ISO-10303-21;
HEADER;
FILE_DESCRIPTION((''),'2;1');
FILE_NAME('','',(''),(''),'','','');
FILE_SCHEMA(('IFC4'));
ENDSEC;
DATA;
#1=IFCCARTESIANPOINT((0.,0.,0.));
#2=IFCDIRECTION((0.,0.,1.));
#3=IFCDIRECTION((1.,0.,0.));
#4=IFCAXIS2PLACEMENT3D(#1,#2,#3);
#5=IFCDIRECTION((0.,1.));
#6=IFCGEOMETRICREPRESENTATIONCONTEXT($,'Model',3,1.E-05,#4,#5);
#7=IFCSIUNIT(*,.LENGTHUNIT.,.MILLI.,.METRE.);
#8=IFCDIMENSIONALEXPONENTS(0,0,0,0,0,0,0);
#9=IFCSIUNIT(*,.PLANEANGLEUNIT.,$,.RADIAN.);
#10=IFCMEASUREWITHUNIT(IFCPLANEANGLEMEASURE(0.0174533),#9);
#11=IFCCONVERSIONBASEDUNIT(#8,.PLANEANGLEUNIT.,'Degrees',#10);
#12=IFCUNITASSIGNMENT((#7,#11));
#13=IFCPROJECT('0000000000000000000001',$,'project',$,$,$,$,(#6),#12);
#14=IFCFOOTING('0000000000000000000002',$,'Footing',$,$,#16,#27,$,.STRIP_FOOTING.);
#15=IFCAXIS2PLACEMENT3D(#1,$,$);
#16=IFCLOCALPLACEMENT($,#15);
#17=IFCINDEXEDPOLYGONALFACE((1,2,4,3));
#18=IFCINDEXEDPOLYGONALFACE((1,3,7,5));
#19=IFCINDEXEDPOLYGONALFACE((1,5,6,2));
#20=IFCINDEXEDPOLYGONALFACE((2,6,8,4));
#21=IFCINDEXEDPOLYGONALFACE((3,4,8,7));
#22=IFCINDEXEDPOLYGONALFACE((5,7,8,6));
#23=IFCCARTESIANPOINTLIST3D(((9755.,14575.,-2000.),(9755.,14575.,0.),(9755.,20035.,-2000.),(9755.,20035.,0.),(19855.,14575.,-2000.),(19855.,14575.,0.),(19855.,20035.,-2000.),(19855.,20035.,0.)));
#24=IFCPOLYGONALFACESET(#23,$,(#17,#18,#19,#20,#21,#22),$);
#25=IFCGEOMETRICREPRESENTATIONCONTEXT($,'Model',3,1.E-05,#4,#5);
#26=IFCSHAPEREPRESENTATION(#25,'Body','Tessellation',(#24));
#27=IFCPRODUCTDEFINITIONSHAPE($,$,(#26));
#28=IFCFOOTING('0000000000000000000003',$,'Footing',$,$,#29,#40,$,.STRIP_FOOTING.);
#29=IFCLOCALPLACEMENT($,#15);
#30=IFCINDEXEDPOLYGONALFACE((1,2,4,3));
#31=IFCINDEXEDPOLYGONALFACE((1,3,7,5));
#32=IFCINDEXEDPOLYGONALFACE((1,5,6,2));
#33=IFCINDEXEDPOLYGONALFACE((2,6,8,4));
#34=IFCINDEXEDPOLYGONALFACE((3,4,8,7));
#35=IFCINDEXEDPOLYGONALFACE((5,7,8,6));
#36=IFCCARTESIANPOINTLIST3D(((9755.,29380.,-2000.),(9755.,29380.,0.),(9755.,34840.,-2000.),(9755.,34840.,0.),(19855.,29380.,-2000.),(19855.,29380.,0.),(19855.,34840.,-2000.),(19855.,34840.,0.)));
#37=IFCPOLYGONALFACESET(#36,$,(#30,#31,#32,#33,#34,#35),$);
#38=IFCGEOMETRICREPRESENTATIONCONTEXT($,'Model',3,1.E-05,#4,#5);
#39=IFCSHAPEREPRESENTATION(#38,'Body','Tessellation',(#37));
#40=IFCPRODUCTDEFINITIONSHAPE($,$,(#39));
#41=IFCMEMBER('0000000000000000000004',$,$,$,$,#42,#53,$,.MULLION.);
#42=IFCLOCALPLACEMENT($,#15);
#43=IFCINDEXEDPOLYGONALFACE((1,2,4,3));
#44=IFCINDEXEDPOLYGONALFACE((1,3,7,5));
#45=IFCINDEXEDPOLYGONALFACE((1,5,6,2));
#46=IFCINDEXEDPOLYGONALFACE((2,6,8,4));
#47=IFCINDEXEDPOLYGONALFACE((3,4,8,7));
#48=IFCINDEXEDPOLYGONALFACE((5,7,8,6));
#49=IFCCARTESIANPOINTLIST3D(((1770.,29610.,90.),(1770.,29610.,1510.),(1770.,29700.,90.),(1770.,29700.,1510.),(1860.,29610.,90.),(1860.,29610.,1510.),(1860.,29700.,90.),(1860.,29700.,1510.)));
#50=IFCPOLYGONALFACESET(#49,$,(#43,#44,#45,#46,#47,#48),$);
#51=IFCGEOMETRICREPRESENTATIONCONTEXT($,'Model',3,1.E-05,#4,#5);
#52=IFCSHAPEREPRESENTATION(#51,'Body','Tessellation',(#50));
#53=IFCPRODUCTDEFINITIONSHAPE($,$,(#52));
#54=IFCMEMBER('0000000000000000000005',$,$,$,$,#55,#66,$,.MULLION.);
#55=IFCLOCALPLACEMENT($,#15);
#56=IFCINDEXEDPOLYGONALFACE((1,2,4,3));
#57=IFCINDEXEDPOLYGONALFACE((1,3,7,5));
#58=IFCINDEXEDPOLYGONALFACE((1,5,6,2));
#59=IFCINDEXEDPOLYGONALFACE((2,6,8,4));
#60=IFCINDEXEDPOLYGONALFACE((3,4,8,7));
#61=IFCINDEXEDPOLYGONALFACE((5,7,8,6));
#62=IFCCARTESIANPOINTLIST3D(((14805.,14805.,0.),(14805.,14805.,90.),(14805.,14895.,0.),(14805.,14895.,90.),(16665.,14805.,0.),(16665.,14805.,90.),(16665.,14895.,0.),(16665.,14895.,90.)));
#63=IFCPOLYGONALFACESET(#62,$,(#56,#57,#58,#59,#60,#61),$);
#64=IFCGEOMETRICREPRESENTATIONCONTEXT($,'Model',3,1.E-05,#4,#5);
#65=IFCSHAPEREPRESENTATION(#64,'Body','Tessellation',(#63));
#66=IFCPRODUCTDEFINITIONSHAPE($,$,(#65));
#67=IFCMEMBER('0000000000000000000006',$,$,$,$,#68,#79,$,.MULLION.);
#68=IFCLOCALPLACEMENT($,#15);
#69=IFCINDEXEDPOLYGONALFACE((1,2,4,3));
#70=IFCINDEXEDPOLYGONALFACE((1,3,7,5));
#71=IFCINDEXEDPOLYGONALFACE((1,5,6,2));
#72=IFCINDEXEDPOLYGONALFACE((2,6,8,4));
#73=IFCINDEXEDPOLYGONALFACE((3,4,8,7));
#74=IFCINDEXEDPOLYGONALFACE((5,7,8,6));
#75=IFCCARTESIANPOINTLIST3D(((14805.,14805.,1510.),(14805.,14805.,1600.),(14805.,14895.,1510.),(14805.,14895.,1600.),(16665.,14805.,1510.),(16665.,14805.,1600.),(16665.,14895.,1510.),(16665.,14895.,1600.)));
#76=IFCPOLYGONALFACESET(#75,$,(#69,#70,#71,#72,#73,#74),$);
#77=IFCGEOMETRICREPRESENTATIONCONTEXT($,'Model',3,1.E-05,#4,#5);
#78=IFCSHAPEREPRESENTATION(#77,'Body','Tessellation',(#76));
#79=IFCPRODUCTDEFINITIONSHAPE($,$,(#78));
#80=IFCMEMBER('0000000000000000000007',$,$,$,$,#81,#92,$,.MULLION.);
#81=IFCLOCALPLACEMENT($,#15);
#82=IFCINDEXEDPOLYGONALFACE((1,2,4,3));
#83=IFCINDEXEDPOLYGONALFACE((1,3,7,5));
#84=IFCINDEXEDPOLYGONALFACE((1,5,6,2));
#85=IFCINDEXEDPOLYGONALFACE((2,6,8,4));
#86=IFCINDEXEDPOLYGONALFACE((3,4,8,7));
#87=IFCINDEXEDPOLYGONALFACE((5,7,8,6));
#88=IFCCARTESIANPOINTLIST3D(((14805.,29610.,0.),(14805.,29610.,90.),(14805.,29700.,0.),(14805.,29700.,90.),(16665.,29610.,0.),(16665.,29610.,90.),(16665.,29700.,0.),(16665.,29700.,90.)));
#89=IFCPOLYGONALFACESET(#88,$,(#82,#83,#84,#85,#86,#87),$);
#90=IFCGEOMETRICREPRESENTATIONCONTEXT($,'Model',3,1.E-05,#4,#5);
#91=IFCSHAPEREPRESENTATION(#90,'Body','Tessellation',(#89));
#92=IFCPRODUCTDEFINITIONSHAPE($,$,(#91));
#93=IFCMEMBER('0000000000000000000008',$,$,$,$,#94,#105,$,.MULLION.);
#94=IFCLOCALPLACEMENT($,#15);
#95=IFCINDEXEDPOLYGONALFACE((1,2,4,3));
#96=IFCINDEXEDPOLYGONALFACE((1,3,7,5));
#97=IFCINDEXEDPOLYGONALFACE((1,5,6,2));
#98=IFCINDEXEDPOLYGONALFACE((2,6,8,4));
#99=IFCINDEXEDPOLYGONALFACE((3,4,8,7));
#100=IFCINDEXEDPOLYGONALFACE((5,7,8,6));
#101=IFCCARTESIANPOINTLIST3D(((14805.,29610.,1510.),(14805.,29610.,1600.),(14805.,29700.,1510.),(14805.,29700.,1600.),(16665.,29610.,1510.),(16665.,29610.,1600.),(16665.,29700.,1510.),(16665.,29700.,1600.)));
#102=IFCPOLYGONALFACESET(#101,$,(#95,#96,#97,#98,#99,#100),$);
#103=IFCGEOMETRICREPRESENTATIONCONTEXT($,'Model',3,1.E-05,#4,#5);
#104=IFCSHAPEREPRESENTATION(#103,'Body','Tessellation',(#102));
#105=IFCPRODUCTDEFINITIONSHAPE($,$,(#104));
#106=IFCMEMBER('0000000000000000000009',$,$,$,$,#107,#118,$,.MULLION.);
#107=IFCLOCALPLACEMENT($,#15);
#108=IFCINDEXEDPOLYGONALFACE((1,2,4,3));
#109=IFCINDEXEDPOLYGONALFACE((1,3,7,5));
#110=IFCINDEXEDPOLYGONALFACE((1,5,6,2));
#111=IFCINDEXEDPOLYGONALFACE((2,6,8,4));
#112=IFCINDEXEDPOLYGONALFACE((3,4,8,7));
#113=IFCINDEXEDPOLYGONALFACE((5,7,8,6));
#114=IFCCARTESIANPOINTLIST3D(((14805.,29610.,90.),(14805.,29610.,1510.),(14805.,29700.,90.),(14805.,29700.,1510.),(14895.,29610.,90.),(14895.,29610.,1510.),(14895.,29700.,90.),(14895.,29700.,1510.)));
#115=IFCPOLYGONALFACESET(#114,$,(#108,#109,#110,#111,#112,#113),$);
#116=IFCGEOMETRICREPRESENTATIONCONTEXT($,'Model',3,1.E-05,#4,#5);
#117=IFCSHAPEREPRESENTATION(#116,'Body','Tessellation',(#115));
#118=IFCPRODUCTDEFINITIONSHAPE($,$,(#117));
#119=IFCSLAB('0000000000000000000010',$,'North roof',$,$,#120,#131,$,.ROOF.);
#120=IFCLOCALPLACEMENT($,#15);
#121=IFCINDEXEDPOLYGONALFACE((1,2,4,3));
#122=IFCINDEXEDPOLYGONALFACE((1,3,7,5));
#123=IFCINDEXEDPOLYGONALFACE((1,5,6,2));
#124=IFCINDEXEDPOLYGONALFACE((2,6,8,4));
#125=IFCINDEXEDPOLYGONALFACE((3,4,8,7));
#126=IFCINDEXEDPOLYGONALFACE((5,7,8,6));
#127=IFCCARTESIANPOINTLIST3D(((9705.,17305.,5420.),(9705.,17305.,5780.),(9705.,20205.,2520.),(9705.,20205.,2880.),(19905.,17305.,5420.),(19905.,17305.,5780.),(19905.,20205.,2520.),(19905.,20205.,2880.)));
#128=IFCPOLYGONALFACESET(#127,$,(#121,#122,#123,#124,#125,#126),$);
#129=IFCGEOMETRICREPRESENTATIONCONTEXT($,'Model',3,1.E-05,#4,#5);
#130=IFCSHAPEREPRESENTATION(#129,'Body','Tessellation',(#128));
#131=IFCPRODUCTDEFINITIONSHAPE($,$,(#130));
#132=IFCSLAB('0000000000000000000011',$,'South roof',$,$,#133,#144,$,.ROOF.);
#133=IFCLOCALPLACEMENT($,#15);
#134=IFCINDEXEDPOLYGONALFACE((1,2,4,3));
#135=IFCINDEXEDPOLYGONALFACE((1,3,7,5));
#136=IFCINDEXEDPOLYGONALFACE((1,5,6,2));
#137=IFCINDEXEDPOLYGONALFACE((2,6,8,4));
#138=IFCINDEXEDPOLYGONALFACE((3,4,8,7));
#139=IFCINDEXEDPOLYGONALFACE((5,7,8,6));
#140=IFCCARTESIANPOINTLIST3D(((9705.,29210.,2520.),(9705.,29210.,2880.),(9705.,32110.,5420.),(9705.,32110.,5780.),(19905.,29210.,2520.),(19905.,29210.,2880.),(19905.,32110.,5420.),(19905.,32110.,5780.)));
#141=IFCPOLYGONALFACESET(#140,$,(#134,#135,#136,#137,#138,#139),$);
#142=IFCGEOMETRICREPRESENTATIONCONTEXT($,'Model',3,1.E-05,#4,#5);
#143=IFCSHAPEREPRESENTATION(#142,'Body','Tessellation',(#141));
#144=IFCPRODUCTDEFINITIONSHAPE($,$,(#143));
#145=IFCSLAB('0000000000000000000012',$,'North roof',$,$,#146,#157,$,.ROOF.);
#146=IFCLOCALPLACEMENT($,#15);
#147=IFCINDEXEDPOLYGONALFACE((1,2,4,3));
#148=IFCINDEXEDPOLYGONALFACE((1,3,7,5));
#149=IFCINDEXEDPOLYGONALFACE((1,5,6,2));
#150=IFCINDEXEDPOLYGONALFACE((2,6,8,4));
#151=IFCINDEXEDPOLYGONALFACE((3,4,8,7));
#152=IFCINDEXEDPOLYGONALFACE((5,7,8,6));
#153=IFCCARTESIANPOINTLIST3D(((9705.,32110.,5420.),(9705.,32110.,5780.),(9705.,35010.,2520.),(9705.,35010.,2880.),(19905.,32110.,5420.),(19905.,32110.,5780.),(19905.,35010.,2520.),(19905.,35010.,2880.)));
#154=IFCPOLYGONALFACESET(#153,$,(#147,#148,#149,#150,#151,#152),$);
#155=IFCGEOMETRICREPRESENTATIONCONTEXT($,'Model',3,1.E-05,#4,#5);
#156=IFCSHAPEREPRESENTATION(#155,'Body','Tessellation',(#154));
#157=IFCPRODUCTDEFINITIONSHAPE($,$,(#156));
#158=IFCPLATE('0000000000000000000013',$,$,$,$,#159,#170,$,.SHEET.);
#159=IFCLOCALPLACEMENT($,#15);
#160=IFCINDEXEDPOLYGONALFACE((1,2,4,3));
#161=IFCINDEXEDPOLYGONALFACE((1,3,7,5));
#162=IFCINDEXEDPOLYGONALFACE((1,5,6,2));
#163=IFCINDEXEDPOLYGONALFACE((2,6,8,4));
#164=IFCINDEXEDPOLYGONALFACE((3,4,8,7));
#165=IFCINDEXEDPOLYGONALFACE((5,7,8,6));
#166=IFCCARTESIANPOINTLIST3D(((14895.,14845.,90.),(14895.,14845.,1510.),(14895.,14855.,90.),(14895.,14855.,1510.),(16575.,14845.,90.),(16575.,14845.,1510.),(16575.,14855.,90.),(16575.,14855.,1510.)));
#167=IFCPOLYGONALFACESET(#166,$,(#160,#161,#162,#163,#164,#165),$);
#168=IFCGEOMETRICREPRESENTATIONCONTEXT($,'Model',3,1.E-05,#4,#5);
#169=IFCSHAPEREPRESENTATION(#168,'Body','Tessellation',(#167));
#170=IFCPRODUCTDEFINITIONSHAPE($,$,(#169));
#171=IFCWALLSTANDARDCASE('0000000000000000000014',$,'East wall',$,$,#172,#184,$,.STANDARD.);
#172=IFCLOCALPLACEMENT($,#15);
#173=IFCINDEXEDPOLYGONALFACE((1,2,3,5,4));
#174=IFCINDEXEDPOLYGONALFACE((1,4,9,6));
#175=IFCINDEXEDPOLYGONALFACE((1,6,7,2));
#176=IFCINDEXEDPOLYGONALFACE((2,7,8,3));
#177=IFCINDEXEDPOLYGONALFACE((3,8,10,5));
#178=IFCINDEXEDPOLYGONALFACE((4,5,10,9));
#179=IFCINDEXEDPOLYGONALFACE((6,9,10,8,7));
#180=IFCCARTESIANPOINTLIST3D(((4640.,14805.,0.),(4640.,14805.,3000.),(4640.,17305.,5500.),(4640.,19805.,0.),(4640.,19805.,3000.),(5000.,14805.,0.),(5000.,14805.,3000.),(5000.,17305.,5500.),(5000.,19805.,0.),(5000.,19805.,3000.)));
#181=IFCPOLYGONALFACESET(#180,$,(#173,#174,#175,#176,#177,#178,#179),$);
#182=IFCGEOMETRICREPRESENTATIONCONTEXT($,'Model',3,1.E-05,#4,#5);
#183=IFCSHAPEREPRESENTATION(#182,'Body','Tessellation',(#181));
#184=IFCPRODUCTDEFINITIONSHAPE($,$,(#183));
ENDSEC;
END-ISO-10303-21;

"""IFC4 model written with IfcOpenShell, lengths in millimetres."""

from ifc_helpers import new_model, entity, si_unit, converted_unit, direction, frame, origin_with_axes, place, context, project, polyline, outline, extrude, clip, halfspace, source, transform, mapped, element, save


model = new_model("IFC4")

# Units and contexts
model_context_1 = context("Model", 3, precision=1e-05, world=origin_with_axes(), true_north=direction((0.0, 1.0)))
model_context_2 = context("Model", 3, precision=1e-05, world=origin_with_axes(), true_north=direction((0.0, 1.0)))
model_context_3 = context("Model", 3, precision=1e-05, world=origin_with_axes(), true_north=direction((0.0, 1.0)))
model_context_4 = context("Model", 3, precision=1e-05, world=origin_with_axes(), true_north=direction((0.0, 1.0)))
model_context_5 = context("Model", 3, precision=1e-05, world=origin_with_axes(), true_north=direction((0.0, 1.0)))
model_context_6 = context("Model", 3, precision=1e-05, world=origin_with_axes(), true_north=direction((0.0, 1.0)))
model_context_7 = context("Model", 3, precision=1e-05, world=origin_with_axes(), true_north=direction((0.0, 1.0)))
model_context_8 = context("Model", 3, precision=1e-05, world=origin_with_axes(), true_north=direction((0.0, 1.0)))
model_context_9 = context("Model", 3, precision=1e-05, world=origin_with_axes(), true_north=direction((0.0, 1.0)))
model_context_10 = context("Model", 3, precision=1e-05, world=origin_with_axes(), true_north=direction((0.0, 1.0)))
model_context_11 = context("Model", 3, precision=1e-05, world=origin_with_axes(), true_north=direction((0.0, 1.0)))
model_context_12 = context("Model", 3, precision=1e-05, world=origin_with_axes(), true_north=direction((0.0, 1.0)))
model_context_13 = context("Model", 3, precision=1e-05, world=origin_with_axes(), true_north=direction((0.0, 1.0)))
model_context_14 = context("Model", 3, precision=1e-05, world=origin_with_axes(), true_north=direction((0.0, 1.0)))
ifc_project = project(units=[si_unit("LENGTHUNIT", "METRE", prefix="MILLI"), converted_unit("PLANEANGLEUNIT", "Degrees", entity("IfcPlaneAngleMeasure", 0.0174533), si_unit("PLANEANGLEUNIT", "RADIAN"), dimensions=[0, 0, 0, 0, 0, 0, 0])], contexts=[model_context_1])

# Footings
placement_1 = place(None, frame((14805.0, 14805.0, 0.0)))
footing_1_placement = place(placement_1, frame((0.0, 2500.0, -2000.0), z_axis=(0.0, 0.0, 1.0), x_axis=(1.0, 0.0, 0.0)))
element("IfcFooting", 1, at=footing_1_placement, Name="Footing", PredefinedType="STRIP_FOOTING", context=model_context_4, shape_type="SweptSolid", body=[
    extrude(outline(polyline([(-5050.0, -2730.0), (5050.0, -2730.0), (5050.0, 2730.0), (-5050.0, 2730.0), (-5050.0, -2730.0), (-5050.0, -2730.0)])), origin_with_axes(), (0.0, 0.0, 1.0), 2000.0),
])
placement_2 = place(None, frame((14805.0, 29610.0, 0.0)))
footing_2_placement = place(placement_2, frame((0.0, 2500.0, -2000.0), z_axis=(0.0, 0.0, 1.0), x_axis=(1.0, 0.0, 0.0)))
element("IfcFooting", 2, at=footing_2_placement, Name="Footing", PredefinedType="STRIP_FOOTING", context=model_context_9, shape_type="SweptSolid", body=[
    extrude(outline(polyline([(-5050.0, -2730.0), (5050.0, -2730.0), (5050.0, 2730.0), (-5050.0, 2730.0), (-5050.0, -2730.0), (-5050.0, -2730.0)])), origin_with_axes(), (0.0, 0.0, 1.0), 2000.0),
])

# Members
shared_shape_1 = source(origin_with_axes(), model_context_3, "Body", "SweptSolid", [
    extrude(outline(polyline([(-45.0, -45.0), (45.0, -45.0), (45.0, 45.0), (-45.0, 45.0), (-45.0, -45.0), (-45.0, -45.0)])), origin_with_axes(), (0.0, 0.0, 1.0), 1420.0),
])
placement_3 = place(None, frame((0.0, 29610.0, 0.0)))
member_1_placement = place(placement_3, frame((1815.0, 45.0, 90.0), z_axis=(0.0, 0.0, 1.0), x_axis=(1.0, 0.0, 0.0)))
element("IfcMember", 3, at=member_1_placement, PredefinedType="MULLION", context=model_context_3, shape_type="MappedRepresentation", body=[
    mapped(shared_shape_1, transform((0.0, 0.0, 0.0))),
])
shared_shape_2 = source(origin_with_axes(), model_context_5, "Body", "SweptSolid", [
    extrude(outline(polyline([(-930.0, -45.0), (930.0, -45.0), (930.0, 45.0), (-930.0, 45.0), (-930.0, -45.0), (-930.0, -45.0)])), origin_with_axes(), (0.0, 0.0, 1.0), 90.0),
])
member_2_placement = place(placement_1, frame((930.0, 45.0, 0.0), z_axis=(0.0, 0.0, 1.0), x_axis=(1.0, 0.0, 0.0)))
element("IfcMember", 4, at=member_2_placement, PredefinedType="MULLION", context=model_context_5, shape_type="MappedRepresentation", body=[
    mapped(shared_shape_2, transform((0.0, 0.0, 0.0))),
])
shared_shape_3 = source(origin_with_axes(), model_context_6, "Body", "SweptSolid", [
    extrude(outline(polyline([(-930.0, -45.0), (930.0, -45.0), (930.0, 45.0), (-930.0, 45.0), (-930.0, -45.0), (-930.0, -45.0)])), origin_with_axes(), (0.0, 0.0, 1.0), 90.0),
])
member_3_placement = place(placement_1, frame((930.0, 45.0, 1510.0), z_axis=(0.0, 0.0, 1.0), x_axis=(1.0, 0.0, 0.0)))
element("IfcMember", 5, at=member_3_placement, PredefinedType="MULLION", context=model_context_6, shape_type="MappedRepresentation", body=[
    mapped(shared_shape_3, transform((0.0, 0.0, 0.0))),
])
shared_shape_4 = source(origin_with_axes(), model_context_10, "Body", "SweptSolid", [
    extrude(outline(polyline([(-930.0, -45.0), (930.0, -45.0), (930.0, 45.0), (-930.0, 45.0), (-930.0, -45.0), (-930.0, -45.0)])), origin_with_axes(), (0.0, 0.0, 1.0), 90.0),
])
member_4_placement = place(placement_2, frame((930.0, 45.0, 0.0), z_axis=(0.0, 0.0, 1.0), x_axis=(1.0, 0.0, 0.0)))
element("IfcMember", 6, at=member_4_placement, PredefinedType="MULLION", context=model_context_10, shape_type="MappedRepresentation", body=[
    mapped(shared_shape_4, transform((0.0, 0.0, 0.0))),
])
shared_shape_5 = source(origin_with_axes(), model_context_11, "Body", "SweptSolid", [
    extrude(outline(polyline([(-930.0, -45.0), (930.0, -45.0), (930.0, 45.0), (-930.0, 45.0), (-930.0, -45.0), (-930.0, -45.0)])), origin_with_axes(), (0.0, 0.0, 1.0), 90.0),
])
member_5_placement = place(placement_2, frame((930.0, 45.0, 1510.0), z_axis=(0.0, 0.0, 1.0), x_axis=(1.0, 0.0, 0.0)))
element("IfcMember", 7, at=member_5_placement, PredefinedType="MULLION", context=model_context_11, shape_type="MappedRepresentation", body=[
    mapped(shared_shape_5, transform((0.0, 0.0, 0.0))),
])
shared_shape_6 = source(origin_with_axes(), model_context_12, "Body", "SweptSolid", [
    extrude(outline(polyline([(-45.0, -45.0), (45.0, -45.0), (45.0, 45.0), (-45.0, 45.0), (-45.0, -45.0), (-45.0, -45.0)])), origin_with_axes(), (0.0, 0.0, 1.0), 1420.0),
])
member_6_placement = place(placement_2, frame((45.0, 45.0, 90.0), z_axis=(0.0, 0.0, 1.0), x_axis=(1.0, 0.0, 0.0)))
element("IfcMember", 8, at=member_6_placement, PredefinedType="MULLION", context=model_context_12, shape_type="MappedRepresentation", body=[
    mapped(shared_shape_6, transform((0.0, 0.0, 0.0))),
])

# Slabs
shared_shape_7 = source(origin_with_axes(), model_context_8, "Body", "SweptSolid", [
    extrude(outline(polyline([(-5100.0, -180.0), (5100.0, -180.0), (5100.0, 180.0), (-5100.0, 180.0), (-5100.0, -180.0), (-5100.0, -180.0)])), frame((0.0, 0.0, 0.0), z_axis=(0.0, 1.0, 0.0), x_axis=(1.0, 0.0, 0.0)), (0.0, -0.707107, 0.707107), 4101.2),
])
slab_1_placement = place(placement_1, frame((0.0, 5400.0, 2700.0), z_axis=(0.0, 0.0, 1.0), x_axis=(-1.0, 0.0, 0.0)))
element("IfcSlab", 9, at=slab_1_placement, Name="North roof", PredefinedType="ROOF", context=model_context_8, shape_type="MappedRepresentation", body=[
    mapped(shared_shape_7, transform((0.0, 0.0, 0.0))),
])
shared_shape_8 = source(origin_with_axes(), model_context_13, "Body", "SweptSolid", [
    extrude(outline(polyline([(-5100.0, -180.0), (5100.0, -180.0), (5100.0, 180.0), (-5100.0, 180.0), (-5100.0, -180.0), (-5100.0, -180.0)])), frame((0.0, 0.0, 0.0), z_axis=(0.0, 1.0, 0.0), x_axis=(1.0, 0.0, 0.0)), (0.0, -0.707107, 0.707107), 4101.2),
])
slab_2_placement = place(placement_2, frame((0.0, -400.0, 2700.0), z_axis=(0.0, 0.0, 1.0), x_axis=(1.0, 0.0, 0.0)))
element("IfcSlab", 10, at=slab_2_placement, Name="South roof", PredefinedType="ROOF", context=model_context_13, shape_type="MappedRepresentation", body=[
    mapped(shared_shape_8, transform((0.0, 0.0, 0.0))),
])
shared_shape_9 = source(origin_with_axes(), model_context_14, "Body", "SweptSolid", [
    extrude(outline(polyline([(-5100.0, -180.0), (5100.0, -180.0), (5100.0, 180.0), (-5100.0, 180.0), (-5100.0, -180.0), (-5100.0, -180.0)])), frame((0.0, 0.0, 0.0), z_axis=(0.0, 1.0, 0.0), x_axis=(1.0, 0.0, 0.0)), (0.0, -0.707107, 0.707107), 4101.2),
])
slab_3_placement = place(placement_2, frame((0.0, 5400.0, 2700.0), z_axis=(0.0, 0.0, 1.0), x_axis=(-1.0, 0.0, 0.0)))
element("IfcSlab", 11, at=slab_3_placement, Name="North roof", PredefinedType="ROOF", context=model_context_14, shape_type="MappedRepresentation", body=[
    mapped(shared_shape_9, transform((0.0, 0.0, 0.0))),
])

# Plate
plate_1_placement = place(placement_1, frame((930.0, 45.0, 90.0), z_axis=(0.0, 0.0, 1.0), x_axis=(1.0, 0.0, 0.0)))
element("IfcPlate", 12, at=plate_1_placement, PredefinedType="SHEET", context=model_context_7, shape_type="SweptSolid", body=[
    extrude(outline(polyline([(-840.0, -5.0), (840.0, -5.0), (840.0, 5.0), (-840.0, 5.0), (-840.0, -5.0), (-840.0, -5.0)])), origin_with_axes(), (0.0, 0.0, 1.0), 1420.0),
])

# Wall
shared_shape_10 = source(origin_with_axes(), model_context_2, "Body", "Clipping", [
    clip(clip(extrude(outline(polyline([(-2500.0, -180.0), (2500.0, -180.0), (2500.0, 180.0), (-2500.0, 180.0), (-2500.0, -180.0), (-2500.0, -180.0)])), origin_with_axes(), (0.0, 0.0, 1.0), 6000.0), halfspace(frame((-2500.0, 0.0, 3000.0), z_axis=(-1.0, 0.0, 1.0), x_axis=(1.0, 0.0, 0.0)), False)), halfspace(frame((2500.0, 0.0, 3000.0), z_axis=(1.0, 0.0, 1.0), x_axis=(1.0, 0.0, 0.0)), False)),
])
placement_4 = place(None, frame((0.0, 14805.0, 0.0)))
wall_1_placement = place(placement_4, frame((4820.0, 2500.0, 0.0), z_axis=(0.0, 0.0, 1.0), x_axis=(0.0, 1.0, 0.0)))
element("IfcWallStandardCase", 13, at=wall_1_placement, Name="East wall", PredefinedType="STANDARD", context=model_context_2, shape_type="MappedRepresentation", body=[
    mapped(shared_shape_10, transform((0.0, 0.0, 0.0))),
])

save(model, "model.ifc")
